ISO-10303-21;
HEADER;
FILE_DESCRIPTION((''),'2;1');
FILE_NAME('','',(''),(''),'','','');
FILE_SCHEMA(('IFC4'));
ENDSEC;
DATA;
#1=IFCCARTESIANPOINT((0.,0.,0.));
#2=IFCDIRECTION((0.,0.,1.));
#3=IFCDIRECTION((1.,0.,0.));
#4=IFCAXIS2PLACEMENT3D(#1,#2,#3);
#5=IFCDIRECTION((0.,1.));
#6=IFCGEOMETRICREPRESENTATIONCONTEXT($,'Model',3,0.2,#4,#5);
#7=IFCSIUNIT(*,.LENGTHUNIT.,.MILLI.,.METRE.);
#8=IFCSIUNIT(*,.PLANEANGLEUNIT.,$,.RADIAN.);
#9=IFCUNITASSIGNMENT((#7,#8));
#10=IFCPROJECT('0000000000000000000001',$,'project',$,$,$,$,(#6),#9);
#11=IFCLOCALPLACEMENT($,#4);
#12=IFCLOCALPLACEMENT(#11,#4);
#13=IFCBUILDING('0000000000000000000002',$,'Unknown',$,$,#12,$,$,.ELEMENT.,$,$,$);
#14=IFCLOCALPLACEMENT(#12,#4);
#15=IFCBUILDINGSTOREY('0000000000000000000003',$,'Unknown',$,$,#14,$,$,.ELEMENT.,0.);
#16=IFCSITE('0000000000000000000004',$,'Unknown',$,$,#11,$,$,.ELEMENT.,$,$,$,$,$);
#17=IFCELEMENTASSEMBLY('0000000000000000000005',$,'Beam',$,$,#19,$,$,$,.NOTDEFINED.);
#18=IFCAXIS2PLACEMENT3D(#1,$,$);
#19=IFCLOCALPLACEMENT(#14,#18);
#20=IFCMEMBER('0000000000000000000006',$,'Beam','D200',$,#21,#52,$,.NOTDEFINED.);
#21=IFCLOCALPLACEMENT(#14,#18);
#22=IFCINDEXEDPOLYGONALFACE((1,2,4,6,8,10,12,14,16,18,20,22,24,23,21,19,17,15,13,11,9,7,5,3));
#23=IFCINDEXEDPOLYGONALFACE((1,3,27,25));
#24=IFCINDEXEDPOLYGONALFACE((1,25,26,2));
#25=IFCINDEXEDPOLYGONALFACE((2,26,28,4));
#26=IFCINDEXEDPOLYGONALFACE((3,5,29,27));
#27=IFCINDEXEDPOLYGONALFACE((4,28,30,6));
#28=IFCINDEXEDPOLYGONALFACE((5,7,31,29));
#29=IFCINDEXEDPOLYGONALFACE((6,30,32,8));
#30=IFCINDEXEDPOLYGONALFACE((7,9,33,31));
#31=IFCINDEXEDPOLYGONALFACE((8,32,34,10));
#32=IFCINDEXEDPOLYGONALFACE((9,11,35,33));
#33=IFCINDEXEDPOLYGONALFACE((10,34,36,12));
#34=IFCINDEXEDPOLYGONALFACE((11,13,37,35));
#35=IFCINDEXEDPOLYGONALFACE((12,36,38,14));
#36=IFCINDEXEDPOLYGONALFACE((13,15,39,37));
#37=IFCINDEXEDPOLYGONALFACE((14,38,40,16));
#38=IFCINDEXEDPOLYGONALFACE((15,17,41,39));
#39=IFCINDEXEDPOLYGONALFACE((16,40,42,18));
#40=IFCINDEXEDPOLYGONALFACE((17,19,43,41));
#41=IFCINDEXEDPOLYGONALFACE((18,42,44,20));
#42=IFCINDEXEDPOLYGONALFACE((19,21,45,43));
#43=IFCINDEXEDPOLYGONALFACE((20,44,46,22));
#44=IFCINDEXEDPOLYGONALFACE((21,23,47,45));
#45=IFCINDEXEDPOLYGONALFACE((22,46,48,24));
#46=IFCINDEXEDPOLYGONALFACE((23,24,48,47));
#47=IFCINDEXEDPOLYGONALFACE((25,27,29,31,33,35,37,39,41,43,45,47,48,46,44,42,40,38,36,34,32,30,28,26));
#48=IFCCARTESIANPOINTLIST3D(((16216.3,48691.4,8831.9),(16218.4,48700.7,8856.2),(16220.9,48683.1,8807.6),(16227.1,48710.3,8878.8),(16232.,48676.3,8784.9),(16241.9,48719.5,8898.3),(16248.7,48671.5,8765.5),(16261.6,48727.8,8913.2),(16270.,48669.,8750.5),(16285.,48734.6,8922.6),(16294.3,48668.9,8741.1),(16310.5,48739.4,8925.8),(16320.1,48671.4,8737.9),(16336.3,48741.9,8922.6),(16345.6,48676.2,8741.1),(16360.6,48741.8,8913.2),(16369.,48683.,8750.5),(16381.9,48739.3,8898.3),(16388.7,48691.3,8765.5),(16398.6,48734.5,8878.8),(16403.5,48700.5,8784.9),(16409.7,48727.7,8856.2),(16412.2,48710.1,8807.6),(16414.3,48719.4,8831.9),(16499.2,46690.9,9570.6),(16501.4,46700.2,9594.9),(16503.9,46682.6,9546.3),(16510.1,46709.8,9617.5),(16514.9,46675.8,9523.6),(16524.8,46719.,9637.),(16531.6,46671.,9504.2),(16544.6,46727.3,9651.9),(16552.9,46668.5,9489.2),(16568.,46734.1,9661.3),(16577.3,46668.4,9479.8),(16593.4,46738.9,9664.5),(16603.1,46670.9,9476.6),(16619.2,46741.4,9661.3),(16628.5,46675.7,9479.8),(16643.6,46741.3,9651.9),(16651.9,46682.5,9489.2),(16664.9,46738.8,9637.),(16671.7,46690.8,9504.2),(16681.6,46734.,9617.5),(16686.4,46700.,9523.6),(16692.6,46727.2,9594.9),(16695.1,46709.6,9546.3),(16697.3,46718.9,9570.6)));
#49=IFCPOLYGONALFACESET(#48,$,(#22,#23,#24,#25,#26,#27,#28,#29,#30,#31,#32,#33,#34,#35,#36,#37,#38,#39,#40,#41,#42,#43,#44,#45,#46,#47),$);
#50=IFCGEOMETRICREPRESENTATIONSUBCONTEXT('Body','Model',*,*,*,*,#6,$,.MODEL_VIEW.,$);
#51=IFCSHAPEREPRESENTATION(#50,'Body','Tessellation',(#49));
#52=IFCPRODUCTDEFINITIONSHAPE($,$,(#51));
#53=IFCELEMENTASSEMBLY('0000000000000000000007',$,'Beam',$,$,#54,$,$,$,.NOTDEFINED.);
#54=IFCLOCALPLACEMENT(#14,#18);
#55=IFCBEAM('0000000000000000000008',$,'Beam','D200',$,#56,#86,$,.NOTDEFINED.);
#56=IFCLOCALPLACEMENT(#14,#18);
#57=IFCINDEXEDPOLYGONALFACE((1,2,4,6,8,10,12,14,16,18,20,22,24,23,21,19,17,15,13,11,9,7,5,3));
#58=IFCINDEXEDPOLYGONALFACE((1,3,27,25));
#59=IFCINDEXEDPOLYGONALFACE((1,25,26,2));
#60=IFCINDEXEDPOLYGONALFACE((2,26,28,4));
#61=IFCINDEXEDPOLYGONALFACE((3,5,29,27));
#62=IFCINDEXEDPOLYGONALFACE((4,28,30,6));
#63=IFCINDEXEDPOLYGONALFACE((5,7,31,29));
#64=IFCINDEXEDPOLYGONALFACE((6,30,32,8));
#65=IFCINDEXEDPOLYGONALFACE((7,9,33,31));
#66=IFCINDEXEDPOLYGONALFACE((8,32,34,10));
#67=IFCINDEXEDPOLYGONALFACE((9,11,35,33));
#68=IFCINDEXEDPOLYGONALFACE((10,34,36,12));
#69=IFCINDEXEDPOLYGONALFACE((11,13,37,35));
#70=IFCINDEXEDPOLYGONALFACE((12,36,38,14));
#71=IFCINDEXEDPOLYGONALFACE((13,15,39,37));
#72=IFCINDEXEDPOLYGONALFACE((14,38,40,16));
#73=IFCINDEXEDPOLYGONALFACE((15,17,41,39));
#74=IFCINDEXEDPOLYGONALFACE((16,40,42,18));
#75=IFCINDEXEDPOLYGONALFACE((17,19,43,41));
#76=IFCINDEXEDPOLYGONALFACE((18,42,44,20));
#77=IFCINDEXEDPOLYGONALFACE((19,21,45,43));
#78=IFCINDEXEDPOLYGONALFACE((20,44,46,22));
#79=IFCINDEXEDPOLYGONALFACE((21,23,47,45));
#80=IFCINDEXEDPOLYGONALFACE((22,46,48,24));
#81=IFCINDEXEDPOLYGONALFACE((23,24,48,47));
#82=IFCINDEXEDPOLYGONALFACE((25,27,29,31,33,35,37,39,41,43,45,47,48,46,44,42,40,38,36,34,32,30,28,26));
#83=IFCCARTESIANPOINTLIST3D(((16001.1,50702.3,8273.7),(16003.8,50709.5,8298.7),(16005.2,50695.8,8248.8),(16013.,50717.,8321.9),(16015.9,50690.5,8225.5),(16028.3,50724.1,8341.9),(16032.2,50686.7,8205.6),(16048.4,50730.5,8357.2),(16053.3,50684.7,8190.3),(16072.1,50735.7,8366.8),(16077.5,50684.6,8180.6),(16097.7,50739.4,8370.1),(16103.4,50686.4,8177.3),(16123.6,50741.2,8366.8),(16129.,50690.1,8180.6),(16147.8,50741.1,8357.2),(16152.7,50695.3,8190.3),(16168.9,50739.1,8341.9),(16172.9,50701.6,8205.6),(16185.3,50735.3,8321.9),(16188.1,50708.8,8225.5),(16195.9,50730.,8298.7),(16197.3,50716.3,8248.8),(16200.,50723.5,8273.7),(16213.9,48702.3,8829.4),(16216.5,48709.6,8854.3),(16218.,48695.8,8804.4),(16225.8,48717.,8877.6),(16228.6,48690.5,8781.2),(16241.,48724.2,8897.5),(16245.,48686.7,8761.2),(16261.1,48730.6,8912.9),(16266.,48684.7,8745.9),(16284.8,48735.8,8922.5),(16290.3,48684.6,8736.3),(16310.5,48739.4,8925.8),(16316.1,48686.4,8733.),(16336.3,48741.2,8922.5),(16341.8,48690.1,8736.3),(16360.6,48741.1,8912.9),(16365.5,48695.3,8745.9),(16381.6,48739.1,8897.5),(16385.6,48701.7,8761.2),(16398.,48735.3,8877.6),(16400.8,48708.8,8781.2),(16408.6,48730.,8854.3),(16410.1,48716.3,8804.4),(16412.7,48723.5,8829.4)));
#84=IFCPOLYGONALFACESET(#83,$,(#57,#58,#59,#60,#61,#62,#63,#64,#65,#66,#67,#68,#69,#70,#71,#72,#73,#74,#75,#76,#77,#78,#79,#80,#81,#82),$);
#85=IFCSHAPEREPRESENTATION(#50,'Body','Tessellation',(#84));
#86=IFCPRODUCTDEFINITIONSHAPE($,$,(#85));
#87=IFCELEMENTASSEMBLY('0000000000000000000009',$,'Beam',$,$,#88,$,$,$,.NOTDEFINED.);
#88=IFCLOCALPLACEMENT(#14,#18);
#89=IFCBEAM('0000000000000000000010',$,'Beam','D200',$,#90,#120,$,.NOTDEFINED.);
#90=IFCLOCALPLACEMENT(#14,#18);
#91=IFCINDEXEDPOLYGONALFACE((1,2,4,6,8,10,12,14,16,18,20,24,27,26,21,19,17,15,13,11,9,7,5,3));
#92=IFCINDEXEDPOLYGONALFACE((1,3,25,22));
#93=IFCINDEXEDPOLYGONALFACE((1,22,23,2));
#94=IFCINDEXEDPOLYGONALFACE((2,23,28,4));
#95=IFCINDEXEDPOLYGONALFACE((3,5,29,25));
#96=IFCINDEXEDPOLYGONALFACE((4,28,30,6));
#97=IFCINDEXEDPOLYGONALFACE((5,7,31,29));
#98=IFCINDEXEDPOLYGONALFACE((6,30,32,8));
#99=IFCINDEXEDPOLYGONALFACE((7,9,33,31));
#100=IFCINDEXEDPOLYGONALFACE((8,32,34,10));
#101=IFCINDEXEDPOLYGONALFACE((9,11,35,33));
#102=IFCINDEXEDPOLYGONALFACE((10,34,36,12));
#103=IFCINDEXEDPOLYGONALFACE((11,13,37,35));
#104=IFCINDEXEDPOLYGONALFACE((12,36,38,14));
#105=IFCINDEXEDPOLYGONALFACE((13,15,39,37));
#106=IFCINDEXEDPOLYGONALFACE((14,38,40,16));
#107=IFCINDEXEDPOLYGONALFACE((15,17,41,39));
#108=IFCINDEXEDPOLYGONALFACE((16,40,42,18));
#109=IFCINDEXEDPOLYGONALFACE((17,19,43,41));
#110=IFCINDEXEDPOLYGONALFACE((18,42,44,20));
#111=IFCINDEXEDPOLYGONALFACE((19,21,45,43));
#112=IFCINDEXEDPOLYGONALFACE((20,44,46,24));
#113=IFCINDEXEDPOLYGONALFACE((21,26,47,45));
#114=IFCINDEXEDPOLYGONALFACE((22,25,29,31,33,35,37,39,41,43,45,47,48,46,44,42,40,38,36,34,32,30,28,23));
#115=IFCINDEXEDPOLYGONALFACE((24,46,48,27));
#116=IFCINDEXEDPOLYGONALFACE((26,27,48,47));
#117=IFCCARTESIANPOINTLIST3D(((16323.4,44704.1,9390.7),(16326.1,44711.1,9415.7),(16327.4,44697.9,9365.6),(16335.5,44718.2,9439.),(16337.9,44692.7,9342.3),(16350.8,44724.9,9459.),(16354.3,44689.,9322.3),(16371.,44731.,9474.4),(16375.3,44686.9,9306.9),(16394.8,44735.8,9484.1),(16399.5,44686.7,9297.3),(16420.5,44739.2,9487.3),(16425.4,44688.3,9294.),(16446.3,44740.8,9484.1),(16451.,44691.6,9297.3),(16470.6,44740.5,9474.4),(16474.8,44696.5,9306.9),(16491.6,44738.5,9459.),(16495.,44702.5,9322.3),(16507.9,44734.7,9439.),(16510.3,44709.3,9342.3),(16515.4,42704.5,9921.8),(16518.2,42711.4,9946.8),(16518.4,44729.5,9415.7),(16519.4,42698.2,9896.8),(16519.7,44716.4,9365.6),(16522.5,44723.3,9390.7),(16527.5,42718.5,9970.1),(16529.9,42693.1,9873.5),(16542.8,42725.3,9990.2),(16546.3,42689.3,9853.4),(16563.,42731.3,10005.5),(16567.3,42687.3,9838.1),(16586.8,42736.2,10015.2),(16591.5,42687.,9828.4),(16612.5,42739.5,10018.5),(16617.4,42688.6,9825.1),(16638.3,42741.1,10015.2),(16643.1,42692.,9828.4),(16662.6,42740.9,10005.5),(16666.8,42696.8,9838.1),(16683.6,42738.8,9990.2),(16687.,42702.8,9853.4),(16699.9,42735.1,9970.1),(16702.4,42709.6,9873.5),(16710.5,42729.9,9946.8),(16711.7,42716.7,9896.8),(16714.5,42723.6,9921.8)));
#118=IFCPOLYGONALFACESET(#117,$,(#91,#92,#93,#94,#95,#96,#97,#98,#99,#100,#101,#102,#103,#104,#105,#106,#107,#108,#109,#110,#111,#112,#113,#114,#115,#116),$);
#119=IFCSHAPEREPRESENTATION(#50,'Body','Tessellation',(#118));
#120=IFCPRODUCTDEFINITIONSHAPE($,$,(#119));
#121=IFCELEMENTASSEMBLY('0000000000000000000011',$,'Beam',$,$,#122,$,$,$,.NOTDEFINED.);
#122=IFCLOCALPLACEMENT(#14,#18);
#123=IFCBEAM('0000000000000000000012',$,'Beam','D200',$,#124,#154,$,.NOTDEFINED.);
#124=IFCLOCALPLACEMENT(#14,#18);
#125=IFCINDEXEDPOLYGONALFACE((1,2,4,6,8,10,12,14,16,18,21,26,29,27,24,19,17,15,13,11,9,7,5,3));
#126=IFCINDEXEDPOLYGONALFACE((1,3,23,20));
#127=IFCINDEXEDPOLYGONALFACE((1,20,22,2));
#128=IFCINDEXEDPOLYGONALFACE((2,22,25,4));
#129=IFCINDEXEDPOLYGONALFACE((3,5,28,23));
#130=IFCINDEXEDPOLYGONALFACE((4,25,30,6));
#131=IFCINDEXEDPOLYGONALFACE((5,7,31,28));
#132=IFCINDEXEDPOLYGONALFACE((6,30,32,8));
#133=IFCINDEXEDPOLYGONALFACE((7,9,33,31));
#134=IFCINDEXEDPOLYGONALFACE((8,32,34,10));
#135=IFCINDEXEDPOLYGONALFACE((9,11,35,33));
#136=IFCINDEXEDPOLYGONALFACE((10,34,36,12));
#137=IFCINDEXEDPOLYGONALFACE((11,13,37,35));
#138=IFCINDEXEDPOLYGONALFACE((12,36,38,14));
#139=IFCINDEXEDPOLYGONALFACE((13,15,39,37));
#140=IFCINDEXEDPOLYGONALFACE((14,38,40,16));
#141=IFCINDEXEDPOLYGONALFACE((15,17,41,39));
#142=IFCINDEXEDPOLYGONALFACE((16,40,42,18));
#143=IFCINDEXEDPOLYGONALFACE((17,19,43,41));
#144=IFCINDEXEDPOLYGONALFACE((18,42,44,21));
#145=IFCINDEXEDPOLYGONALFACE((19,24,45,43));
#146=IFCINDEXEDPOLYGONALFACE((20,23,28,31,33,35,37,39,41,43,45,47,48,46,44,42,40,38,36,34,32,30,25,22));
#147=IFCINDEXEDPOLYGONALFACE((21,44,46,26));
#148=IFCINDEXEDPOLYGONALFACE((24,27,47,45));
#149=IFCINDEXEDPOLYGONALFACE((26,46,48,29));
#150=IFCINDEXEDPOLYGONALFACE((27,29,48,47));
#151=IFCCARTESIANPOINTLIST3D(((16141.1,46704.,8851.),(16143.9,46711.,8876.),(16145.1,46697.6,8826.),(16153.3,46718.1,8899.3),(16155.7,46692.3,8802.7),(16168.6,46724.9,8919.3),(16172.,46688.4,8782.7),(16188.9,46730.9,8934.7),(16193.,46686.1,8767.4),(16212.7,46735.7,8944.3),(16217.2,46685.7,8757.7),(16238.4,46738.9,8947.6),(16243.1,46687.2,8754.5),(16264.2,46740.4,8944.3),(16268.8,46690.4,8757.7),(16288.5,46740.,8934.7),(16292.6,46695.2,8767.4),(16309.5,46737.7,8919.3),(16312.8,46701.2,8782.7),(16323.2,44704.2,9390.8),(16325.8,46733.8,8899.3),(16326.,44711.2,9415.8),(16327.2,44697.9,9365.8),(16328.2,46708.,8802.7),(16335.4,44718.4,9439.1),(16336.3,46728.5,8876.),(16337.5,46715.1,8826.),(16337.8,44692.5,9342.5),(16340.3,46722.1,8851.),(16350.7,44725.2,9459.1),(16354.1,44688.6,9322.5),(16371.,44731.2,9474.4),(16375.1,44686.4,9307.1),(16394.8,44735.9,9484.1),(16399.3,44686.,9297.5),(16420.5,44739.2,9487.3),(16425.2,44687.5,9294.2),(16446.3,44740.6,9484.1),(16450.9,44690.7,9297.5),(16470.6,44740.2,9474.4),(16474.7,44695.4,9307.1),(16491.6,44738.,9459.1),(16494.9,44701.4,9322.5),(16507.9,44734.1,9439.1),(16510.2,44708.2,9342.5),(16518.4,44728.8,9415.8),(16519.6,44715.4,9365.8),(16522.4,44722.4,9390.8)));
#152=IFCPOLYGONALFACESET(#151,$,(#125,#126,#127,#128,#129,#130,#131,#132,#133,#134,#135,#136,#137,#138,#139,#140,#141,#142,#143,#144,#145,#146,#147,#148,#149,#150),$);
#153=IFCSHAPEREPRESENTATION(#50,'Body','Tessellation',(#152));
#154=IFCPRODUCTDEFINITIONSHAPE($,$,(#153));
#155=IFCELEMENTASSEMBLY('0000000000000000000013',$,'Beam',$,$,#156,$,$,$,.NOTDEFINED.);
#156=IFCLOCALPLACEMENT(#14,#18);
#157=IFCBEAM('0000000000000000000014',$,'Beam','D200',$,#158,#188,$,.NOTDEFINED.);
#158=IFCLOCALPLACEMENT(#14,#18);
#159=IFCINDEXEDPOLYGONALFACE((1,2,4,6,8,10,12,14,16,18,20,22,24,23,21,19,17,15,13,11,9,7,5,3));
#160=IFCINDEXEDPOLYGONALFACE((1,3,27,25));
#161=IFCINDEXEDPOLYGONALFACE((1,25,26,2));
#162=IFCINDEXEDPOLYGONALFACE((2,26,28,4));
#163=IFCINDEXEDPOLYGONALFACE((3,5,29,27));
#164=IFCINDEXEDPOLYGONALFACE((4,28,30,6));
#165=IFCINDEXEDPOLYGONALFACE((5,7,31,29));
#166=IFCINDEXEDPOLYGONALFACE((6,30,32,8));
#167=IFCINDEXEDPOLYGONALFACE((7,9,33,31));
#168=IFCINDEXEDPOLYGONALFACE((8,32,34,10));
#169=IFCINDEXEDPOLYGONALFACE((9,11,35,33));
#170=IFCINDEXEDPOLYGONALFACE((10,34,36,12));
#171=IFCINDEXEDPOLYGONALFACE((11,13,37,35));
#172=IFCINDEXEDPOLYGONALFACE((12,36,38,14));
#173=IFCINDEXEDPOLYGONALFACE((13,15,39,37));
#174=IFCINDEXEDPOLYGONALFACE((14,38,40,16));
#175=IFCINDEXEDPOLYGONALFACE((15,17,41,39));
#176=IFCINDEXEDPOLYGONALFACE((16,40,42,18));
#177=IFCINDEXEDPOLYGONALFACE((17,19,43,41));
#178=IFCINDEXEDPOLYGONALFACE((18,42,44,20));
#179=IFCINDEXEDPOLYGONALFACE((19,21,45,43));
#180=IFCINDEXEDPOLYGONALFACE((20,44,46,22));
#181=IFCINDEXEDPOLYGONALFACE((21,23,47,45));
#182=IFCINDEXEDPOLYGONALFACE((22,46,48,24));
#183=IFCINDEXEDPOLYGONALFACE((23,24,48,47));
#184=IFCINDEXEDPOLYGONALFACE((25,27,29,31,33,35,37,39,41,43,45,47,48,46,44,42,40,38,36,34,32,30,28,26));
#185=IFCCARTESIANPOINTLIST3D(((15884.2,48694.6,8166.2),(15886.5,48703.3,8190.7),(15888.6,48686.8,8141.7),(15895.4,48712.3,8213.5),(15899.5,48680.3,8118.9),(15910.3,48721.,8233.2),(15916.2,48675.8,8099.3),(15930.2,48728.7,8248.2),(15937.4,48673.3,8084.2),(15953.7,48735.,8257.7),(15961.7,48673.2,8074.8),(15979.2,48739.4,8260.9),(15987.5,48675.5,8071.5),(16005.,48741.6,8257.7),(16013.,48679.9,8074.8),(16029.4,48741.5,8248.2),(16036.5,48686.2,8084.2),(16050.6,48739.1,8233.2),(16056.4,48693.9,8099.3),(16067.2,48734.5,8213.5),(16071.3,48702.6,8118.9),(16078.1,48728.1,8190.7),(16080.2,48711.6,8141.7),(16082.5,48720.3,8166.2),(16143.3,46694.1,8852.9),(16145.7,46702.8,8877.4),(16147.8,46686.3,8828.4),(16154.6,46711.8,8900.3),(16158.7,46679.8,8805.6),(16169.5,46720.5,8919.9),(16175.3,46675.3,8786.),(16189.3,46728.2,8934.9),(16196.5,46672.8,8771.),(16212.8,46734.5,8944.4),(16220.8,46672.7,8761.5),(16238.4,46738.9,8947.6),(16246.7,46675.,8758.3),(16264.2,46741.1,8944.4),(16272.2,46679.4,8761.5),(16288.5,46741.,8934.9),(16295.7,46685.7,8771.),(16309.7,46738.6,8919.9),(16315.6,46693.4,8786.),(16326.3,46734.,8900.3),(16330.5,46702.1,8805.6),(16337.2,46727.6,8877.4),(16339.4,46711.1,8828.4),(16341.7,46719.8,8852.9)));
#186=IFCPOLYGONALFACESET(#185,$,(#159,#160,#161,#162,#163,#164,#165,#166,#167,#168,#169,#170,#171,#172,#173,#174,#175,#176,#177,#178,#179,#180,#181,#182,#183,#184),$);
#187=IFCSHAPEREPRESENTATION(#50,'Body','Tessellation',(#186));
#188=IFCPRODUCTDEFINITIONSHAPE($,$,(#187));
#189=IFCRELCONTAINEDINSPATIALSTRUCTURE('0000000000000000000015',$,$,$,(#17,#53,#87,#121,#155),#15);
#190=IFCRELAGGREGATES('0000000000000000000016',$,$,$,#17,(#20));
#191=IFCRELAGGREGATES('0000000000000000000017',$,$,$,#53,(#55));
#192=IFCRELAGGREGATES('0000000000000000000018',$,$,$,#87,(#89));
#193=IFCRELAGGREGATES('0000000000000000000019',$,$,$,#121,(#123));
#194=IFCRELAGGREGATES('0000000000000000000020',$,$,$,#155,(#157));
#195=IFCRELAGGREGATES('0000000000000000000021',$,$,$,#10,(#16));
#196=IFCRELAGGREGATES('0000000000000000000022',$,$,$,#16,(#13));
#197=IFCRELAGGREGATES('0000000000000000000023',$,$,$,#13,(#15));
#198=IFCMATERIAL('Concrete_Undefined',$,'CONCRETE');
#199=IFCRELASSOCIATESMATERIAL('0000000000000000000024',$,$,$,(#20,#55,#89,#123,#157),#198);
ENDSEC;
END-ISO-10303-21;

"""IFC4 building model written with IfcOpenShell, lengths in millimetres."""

from ifc_helpers import new_model, si_unit, direction, frame, origin_with_axes, place, context, subcontext, project, spatial, line, indexed_curve, outline, extrude, material, element, aggregate, save


model = new_model("IFC4")

# Units and contexts
model_context = context("Model", 3, precision=0.2, world=origin_with_axes(), true_north=direction((0.0, 1.0)))
body_context = subcontext(model_context, "Body", "Model", "MODEL_VIEW")
ifc_project = project(units=[si_unit("LENGTHUNIT", "METRE", prefix="MILLI"), si_unit("PLANEANGLEUNIT", "RADIAN")], contexts=[model_context])

# Site, building, storey
site_placement = place(None, origin_with_axes())
site = spatial("IfcSite", under=ifc_project, at=site_placement, Name="Unknown", CompositionType="ELEMENT")
building_placement = place(site_placement, origin_with_axes())
building = spatial("IfcBuilding", under=site, at=building_placement, Name="Unknown", CompositionType="ELEMENT")
storey_placement = place(building_placement, origin_with_axes())
storey = spatial("IfcBuildingStorey", under=building, at=storey_placement, Name="Unknown", CompositionType="ELEMENT", Elevation=0.0)

# Shared definitions
ifc_material = material(Name="Concrete_Undefined", Category="CONCRETE")

# Element assembly, member
assembly_1_placement = place(storey_placement, frame((16315.3, 48705.4, 8831.9), z_axis=(-0.990145, -0.140047, 0.0), x_axis=(0.131531, -0.929937, 0.34339)))
assembly_1 = element("IfcElementAssembly", 1, at=assembly_1_placement, inside=storey, Name="Beam", PredefinedType="NOTDEFINED")
member_1_placement = place(assembly_1_placement, origin_with_axes())
member_1 = element("IfcMember", 2, at=member_1_placement, material=ifc_material, Name="Beam", Description="D200", PredefinedType="NOTDEFINED", context=body_context, shape_type="SolidModel", body=[
    extrude(outline(indexed_curve([(100.0, 0.0), (96.6, 25.9), (86.6, 50.0), (70.7, 70.7), (50.0, 86.6), (25.9, 96.6), (0.0, 100.0), (-25.9, 96.6), (-50.0, 86.6), (-70.7, 70.7), (-86.6, 50.0), (-96.6, 25.9), (-100.0, 0.0), (-96.6, -25.9), (-86.6, -50.0), (-70.7, -70.7), (-50.0, -86.6), (-25.9, -96.6), (0.0, -100.0), (25.9, -96.6), (50.0, -86.6), (70.7, -70.7), (86.6, -50.0), (96.6, -25.9)], segments=[line(1, 2, 3, 4, 5, 6, 7, 8, 9, 10, 11, 12, 13, 14, 15, 16, 17, 18, 19, 20, 21, 22, 23, 24, 1)])), frame((0.0, 0.0, 0.0), z_axis=(-1.0, 0.0, 0.0), x_axis=(0.0, 0.0, 1.0)), (0.0, 0.0, -1.0), 2151.2),
])
aggregate(assembly_1, [member_1])

# Element assemblies, beams
assembly_2_placement = place(storey_placement, frame((16100.6, 50712.9, 8273.7), z_axis=(-0.99439, -0.105777, 0.0), x_axis=(0.101957, -0.958483, 0.266299)))
assembly_2 = element("IfcElementAssembly", 3, at=assembly_2_placement, inside=storey, Name="Beam", PredefinedType="NOTDEFINED")
beam_1_placement = place(assembly_2_placement, origin_with_axes())
beam_1 = element("IfcBeam", 4, at=beam_1_placement, material=ifc_material, Name="Beam", Description="D200", PredefinedType="NOTDEFINED", context=body_context, shape_type="SolidModel", body=[
    extrude(outline(indexed_curve([(100.0, 0.0), (96.6, 25.9), (86.6, 50.0), (70.7, 70.7), (50.0, 86.6), (25.9, 96.6), (0.0, 100.0), (-25.9, 96.6), (-50.0, 86.6), (-70.7, 70.7), (-86.6, 50.0), (-96.6, 25.9), (-100.0, 0.0), (-96.6, -25.9), (-86.6, -50.0), (-70.7, -70.7), (-50.0, -86.6), (-25.9, -96.6), (0.0, -100.0), (25.9, -96.6), (50.0, -86.6), (70.7, -70.7), (86.6, -50.0), (96.6, -25.9)], segments=[line(1, 2, 3, 4, 5, 6, 7, 8, 9, 10, 11, 12, 13, 14, 15, 16, 17, 18, 19, 20, 21, 22, 23, 24, 1)])), frame((0.0, 0.0, 0.0), z_axis=(-1.0, 0.0, 0.0), x_axis=(0.0, 0.0, 1.0)), (0.0, 0.0, -1.0), 2086.6),
])
aggregate(assembly_2, [beam_1])
assembly_3_placement = place(storey_placement, frame((16422.9, 44713.7, 9390.7), z_axis=(-0.995421, -0.095587, 0.0), x_axis=(0.092411, -0.962351, 0.255619)))
assembly_3 = element("IfcElementAssembly", 5, at=assembly_3_placement, inside=storey, Name="Beam", PredefinedType="NOTDEFINED")
beam_2_placement = place(assembly_3_placement, origin_with_axes())
beam_2 = element("IfcBeam", 6, at=beam_2_placement, material=ifc_material, Name="Beam", Description="D200", PredefinedType="NOTDEFINED", context=body_context, shape_type="SolidModel", body=[
    extrude(outline(indexed_curve([(100.0, 0.0), (96.6, 25.9), (86.6, 50.0), (70.7, 70.7), (50.0, 86.6), (25.9, 96.6), (0.0, 100.0), (-25.9, 96.6), (-50.0, 86.6), (-70.7, 70.7), (-86.6, 50.0), (-96.6, 25.9), (-100.0, 0.0), (-96.6, -25.9), (-86.6, -50.0), (-70.7, -70.7), (-50.0, -86.6), (-25.9, -96.6), (0.0, -100.0), (25.9, -96.6), (50.0, -86.6), (70.7, -70.7), (86.6, -50.0), (96.6, -25.9)], segments=[line(1, 2, 3, 4, 5, 6, 7, 8, 9, 10, 11, 12, 13, 14, 15, 16, 17, 18, 19, 20, 21, 22, 23, 24, 1)])), frame((0.0, 0.0, 0.0), z_axis=(-1.0, 0.0, 0.0), x_axis=(0.0, 0.0, 1.0)), (0.0, 0.0, -1.0), 2077.9),
])
aggregate(assembly_3, [beam_2])
assembly_4_placement = place(storey_placement, frame((16240.7, 46713.0, 8851.0), z_axis=(-0.99588, -0.090685, 0.0), x_axis=(0.087576, -0.961742, 0.259581)))
assembly_4 = element("IfcElementAssembly", 7, at=assembly_4_placement, inside=storey, Name="Beam", PredefinedType="NOTDEFINED")
beam_3_placement = place(assembly_4_placement, origin_with_axes())
beam_3 = element("IfcBeam", 8, at=beam_3_placement, material=ifc_material, Name="Beam", Description="D200", PredefinedType="NOTDEFINED", context=body_context, shape_type="SolidModel", body=[
    extrude(outline(indexed_curve([(100.0, 0.0), (96.6, 25.9), (86.6, 50.0), (70.7, 70.7), (50.0, 86.6), (25.9, 96.6), (0.0, 100.0), (-25.9, 96.6), (-50.0, 86.6), (-70.7, 70.7), (-86.6, 50.0), (-96.6, 25.9), (-100.0, 0.0), (-96.6, -25.9), (-86.6, -50.0), (-70.7, -70.7), (-50.0, -86.6), (-25.9, -96.6), (0.0, -100.0), (25.9, -96.6), (50.0, -86.6), (70.7, -70.7), (86.6, -50.0), (96.6, -25.9)], segments=[line(1, 2, 3, 4, 5, 6, 7, 8, 9, 10, 11, 12, 13, 14, 15, 16, 17, 18, 19, 20, 21, 22, 23, 24, 1)])), frame((0.0, 0.0, 0.0), z_axis=(-1.0, 0.0, 0.0), x_axis=(0.0, 0.0, 1.0)), (0.0, 0.0, -1.0), 2079.3),
])
aggregate(assembly_4, [beam_3])
assembly_5_placement = place(storey_placement, frame((15983.4, 48707.4, 8166.2), z_axis=(-0.991713, -0.128474, 0.0), x_axis=(0.12162, -0.938804, 0.322267)))
assembly_5 = element("IfcElementAssembly", 9, at=assembly_5_placement, inside=storey, Name="Beam", PredefinedType="NOTDEFINED")
beam_4_placement = place(assembly_5_placement, origin_with_axes())
beam_4 = element("IfcBeam", 10, at=beam_4_placement, material=ifc_material, Name="Beam", Description="D200", PredefinedType="NOTDEFINED", context=body_context, shape_type="SolidModel", body=[
    extrude(outline(indexed_curve([(100.0, 0.0), (96.6, 25.9), (86.6, 50.0), (70.7, 70.7), (50.0, 86.6), (25.9, 96.6), (0.0, 100.0), (-25.9, 96.6), (-50.0, 86.6), (-70.7, 70.7), (-86.6, 50.0), (-96.6, 25.9), (-100.0, 0.0), (-96.6, -25.9), (-86.6, -50.0), (-70.7, -70.7), (-50.0, -86.6), (-25.9, -96.6), (0.0, -100.0), (25.9, -96.6), (50.0, -86.6), (70.7, -70.7), (86.6, -50.0), (96.6, -25.9)], segments=[line(1, 2, 3, 4, 5, 6, 7, 8, 9, 10, 11, 12, 13, 14, 15, 16, 17, 18, 19, 20, 21, 22, 23, 24, 1)])), frame((0.0, 0.0, 0.0), z_axis=(-1.0, 0.0, 0.0), x_axis=(0.0, 0.0, 1.0)), (0.0, 0.0, -1.0), 2130.9),
])
aggregate(assembly_5, [beam_4])

save(model, "model.ifc")
